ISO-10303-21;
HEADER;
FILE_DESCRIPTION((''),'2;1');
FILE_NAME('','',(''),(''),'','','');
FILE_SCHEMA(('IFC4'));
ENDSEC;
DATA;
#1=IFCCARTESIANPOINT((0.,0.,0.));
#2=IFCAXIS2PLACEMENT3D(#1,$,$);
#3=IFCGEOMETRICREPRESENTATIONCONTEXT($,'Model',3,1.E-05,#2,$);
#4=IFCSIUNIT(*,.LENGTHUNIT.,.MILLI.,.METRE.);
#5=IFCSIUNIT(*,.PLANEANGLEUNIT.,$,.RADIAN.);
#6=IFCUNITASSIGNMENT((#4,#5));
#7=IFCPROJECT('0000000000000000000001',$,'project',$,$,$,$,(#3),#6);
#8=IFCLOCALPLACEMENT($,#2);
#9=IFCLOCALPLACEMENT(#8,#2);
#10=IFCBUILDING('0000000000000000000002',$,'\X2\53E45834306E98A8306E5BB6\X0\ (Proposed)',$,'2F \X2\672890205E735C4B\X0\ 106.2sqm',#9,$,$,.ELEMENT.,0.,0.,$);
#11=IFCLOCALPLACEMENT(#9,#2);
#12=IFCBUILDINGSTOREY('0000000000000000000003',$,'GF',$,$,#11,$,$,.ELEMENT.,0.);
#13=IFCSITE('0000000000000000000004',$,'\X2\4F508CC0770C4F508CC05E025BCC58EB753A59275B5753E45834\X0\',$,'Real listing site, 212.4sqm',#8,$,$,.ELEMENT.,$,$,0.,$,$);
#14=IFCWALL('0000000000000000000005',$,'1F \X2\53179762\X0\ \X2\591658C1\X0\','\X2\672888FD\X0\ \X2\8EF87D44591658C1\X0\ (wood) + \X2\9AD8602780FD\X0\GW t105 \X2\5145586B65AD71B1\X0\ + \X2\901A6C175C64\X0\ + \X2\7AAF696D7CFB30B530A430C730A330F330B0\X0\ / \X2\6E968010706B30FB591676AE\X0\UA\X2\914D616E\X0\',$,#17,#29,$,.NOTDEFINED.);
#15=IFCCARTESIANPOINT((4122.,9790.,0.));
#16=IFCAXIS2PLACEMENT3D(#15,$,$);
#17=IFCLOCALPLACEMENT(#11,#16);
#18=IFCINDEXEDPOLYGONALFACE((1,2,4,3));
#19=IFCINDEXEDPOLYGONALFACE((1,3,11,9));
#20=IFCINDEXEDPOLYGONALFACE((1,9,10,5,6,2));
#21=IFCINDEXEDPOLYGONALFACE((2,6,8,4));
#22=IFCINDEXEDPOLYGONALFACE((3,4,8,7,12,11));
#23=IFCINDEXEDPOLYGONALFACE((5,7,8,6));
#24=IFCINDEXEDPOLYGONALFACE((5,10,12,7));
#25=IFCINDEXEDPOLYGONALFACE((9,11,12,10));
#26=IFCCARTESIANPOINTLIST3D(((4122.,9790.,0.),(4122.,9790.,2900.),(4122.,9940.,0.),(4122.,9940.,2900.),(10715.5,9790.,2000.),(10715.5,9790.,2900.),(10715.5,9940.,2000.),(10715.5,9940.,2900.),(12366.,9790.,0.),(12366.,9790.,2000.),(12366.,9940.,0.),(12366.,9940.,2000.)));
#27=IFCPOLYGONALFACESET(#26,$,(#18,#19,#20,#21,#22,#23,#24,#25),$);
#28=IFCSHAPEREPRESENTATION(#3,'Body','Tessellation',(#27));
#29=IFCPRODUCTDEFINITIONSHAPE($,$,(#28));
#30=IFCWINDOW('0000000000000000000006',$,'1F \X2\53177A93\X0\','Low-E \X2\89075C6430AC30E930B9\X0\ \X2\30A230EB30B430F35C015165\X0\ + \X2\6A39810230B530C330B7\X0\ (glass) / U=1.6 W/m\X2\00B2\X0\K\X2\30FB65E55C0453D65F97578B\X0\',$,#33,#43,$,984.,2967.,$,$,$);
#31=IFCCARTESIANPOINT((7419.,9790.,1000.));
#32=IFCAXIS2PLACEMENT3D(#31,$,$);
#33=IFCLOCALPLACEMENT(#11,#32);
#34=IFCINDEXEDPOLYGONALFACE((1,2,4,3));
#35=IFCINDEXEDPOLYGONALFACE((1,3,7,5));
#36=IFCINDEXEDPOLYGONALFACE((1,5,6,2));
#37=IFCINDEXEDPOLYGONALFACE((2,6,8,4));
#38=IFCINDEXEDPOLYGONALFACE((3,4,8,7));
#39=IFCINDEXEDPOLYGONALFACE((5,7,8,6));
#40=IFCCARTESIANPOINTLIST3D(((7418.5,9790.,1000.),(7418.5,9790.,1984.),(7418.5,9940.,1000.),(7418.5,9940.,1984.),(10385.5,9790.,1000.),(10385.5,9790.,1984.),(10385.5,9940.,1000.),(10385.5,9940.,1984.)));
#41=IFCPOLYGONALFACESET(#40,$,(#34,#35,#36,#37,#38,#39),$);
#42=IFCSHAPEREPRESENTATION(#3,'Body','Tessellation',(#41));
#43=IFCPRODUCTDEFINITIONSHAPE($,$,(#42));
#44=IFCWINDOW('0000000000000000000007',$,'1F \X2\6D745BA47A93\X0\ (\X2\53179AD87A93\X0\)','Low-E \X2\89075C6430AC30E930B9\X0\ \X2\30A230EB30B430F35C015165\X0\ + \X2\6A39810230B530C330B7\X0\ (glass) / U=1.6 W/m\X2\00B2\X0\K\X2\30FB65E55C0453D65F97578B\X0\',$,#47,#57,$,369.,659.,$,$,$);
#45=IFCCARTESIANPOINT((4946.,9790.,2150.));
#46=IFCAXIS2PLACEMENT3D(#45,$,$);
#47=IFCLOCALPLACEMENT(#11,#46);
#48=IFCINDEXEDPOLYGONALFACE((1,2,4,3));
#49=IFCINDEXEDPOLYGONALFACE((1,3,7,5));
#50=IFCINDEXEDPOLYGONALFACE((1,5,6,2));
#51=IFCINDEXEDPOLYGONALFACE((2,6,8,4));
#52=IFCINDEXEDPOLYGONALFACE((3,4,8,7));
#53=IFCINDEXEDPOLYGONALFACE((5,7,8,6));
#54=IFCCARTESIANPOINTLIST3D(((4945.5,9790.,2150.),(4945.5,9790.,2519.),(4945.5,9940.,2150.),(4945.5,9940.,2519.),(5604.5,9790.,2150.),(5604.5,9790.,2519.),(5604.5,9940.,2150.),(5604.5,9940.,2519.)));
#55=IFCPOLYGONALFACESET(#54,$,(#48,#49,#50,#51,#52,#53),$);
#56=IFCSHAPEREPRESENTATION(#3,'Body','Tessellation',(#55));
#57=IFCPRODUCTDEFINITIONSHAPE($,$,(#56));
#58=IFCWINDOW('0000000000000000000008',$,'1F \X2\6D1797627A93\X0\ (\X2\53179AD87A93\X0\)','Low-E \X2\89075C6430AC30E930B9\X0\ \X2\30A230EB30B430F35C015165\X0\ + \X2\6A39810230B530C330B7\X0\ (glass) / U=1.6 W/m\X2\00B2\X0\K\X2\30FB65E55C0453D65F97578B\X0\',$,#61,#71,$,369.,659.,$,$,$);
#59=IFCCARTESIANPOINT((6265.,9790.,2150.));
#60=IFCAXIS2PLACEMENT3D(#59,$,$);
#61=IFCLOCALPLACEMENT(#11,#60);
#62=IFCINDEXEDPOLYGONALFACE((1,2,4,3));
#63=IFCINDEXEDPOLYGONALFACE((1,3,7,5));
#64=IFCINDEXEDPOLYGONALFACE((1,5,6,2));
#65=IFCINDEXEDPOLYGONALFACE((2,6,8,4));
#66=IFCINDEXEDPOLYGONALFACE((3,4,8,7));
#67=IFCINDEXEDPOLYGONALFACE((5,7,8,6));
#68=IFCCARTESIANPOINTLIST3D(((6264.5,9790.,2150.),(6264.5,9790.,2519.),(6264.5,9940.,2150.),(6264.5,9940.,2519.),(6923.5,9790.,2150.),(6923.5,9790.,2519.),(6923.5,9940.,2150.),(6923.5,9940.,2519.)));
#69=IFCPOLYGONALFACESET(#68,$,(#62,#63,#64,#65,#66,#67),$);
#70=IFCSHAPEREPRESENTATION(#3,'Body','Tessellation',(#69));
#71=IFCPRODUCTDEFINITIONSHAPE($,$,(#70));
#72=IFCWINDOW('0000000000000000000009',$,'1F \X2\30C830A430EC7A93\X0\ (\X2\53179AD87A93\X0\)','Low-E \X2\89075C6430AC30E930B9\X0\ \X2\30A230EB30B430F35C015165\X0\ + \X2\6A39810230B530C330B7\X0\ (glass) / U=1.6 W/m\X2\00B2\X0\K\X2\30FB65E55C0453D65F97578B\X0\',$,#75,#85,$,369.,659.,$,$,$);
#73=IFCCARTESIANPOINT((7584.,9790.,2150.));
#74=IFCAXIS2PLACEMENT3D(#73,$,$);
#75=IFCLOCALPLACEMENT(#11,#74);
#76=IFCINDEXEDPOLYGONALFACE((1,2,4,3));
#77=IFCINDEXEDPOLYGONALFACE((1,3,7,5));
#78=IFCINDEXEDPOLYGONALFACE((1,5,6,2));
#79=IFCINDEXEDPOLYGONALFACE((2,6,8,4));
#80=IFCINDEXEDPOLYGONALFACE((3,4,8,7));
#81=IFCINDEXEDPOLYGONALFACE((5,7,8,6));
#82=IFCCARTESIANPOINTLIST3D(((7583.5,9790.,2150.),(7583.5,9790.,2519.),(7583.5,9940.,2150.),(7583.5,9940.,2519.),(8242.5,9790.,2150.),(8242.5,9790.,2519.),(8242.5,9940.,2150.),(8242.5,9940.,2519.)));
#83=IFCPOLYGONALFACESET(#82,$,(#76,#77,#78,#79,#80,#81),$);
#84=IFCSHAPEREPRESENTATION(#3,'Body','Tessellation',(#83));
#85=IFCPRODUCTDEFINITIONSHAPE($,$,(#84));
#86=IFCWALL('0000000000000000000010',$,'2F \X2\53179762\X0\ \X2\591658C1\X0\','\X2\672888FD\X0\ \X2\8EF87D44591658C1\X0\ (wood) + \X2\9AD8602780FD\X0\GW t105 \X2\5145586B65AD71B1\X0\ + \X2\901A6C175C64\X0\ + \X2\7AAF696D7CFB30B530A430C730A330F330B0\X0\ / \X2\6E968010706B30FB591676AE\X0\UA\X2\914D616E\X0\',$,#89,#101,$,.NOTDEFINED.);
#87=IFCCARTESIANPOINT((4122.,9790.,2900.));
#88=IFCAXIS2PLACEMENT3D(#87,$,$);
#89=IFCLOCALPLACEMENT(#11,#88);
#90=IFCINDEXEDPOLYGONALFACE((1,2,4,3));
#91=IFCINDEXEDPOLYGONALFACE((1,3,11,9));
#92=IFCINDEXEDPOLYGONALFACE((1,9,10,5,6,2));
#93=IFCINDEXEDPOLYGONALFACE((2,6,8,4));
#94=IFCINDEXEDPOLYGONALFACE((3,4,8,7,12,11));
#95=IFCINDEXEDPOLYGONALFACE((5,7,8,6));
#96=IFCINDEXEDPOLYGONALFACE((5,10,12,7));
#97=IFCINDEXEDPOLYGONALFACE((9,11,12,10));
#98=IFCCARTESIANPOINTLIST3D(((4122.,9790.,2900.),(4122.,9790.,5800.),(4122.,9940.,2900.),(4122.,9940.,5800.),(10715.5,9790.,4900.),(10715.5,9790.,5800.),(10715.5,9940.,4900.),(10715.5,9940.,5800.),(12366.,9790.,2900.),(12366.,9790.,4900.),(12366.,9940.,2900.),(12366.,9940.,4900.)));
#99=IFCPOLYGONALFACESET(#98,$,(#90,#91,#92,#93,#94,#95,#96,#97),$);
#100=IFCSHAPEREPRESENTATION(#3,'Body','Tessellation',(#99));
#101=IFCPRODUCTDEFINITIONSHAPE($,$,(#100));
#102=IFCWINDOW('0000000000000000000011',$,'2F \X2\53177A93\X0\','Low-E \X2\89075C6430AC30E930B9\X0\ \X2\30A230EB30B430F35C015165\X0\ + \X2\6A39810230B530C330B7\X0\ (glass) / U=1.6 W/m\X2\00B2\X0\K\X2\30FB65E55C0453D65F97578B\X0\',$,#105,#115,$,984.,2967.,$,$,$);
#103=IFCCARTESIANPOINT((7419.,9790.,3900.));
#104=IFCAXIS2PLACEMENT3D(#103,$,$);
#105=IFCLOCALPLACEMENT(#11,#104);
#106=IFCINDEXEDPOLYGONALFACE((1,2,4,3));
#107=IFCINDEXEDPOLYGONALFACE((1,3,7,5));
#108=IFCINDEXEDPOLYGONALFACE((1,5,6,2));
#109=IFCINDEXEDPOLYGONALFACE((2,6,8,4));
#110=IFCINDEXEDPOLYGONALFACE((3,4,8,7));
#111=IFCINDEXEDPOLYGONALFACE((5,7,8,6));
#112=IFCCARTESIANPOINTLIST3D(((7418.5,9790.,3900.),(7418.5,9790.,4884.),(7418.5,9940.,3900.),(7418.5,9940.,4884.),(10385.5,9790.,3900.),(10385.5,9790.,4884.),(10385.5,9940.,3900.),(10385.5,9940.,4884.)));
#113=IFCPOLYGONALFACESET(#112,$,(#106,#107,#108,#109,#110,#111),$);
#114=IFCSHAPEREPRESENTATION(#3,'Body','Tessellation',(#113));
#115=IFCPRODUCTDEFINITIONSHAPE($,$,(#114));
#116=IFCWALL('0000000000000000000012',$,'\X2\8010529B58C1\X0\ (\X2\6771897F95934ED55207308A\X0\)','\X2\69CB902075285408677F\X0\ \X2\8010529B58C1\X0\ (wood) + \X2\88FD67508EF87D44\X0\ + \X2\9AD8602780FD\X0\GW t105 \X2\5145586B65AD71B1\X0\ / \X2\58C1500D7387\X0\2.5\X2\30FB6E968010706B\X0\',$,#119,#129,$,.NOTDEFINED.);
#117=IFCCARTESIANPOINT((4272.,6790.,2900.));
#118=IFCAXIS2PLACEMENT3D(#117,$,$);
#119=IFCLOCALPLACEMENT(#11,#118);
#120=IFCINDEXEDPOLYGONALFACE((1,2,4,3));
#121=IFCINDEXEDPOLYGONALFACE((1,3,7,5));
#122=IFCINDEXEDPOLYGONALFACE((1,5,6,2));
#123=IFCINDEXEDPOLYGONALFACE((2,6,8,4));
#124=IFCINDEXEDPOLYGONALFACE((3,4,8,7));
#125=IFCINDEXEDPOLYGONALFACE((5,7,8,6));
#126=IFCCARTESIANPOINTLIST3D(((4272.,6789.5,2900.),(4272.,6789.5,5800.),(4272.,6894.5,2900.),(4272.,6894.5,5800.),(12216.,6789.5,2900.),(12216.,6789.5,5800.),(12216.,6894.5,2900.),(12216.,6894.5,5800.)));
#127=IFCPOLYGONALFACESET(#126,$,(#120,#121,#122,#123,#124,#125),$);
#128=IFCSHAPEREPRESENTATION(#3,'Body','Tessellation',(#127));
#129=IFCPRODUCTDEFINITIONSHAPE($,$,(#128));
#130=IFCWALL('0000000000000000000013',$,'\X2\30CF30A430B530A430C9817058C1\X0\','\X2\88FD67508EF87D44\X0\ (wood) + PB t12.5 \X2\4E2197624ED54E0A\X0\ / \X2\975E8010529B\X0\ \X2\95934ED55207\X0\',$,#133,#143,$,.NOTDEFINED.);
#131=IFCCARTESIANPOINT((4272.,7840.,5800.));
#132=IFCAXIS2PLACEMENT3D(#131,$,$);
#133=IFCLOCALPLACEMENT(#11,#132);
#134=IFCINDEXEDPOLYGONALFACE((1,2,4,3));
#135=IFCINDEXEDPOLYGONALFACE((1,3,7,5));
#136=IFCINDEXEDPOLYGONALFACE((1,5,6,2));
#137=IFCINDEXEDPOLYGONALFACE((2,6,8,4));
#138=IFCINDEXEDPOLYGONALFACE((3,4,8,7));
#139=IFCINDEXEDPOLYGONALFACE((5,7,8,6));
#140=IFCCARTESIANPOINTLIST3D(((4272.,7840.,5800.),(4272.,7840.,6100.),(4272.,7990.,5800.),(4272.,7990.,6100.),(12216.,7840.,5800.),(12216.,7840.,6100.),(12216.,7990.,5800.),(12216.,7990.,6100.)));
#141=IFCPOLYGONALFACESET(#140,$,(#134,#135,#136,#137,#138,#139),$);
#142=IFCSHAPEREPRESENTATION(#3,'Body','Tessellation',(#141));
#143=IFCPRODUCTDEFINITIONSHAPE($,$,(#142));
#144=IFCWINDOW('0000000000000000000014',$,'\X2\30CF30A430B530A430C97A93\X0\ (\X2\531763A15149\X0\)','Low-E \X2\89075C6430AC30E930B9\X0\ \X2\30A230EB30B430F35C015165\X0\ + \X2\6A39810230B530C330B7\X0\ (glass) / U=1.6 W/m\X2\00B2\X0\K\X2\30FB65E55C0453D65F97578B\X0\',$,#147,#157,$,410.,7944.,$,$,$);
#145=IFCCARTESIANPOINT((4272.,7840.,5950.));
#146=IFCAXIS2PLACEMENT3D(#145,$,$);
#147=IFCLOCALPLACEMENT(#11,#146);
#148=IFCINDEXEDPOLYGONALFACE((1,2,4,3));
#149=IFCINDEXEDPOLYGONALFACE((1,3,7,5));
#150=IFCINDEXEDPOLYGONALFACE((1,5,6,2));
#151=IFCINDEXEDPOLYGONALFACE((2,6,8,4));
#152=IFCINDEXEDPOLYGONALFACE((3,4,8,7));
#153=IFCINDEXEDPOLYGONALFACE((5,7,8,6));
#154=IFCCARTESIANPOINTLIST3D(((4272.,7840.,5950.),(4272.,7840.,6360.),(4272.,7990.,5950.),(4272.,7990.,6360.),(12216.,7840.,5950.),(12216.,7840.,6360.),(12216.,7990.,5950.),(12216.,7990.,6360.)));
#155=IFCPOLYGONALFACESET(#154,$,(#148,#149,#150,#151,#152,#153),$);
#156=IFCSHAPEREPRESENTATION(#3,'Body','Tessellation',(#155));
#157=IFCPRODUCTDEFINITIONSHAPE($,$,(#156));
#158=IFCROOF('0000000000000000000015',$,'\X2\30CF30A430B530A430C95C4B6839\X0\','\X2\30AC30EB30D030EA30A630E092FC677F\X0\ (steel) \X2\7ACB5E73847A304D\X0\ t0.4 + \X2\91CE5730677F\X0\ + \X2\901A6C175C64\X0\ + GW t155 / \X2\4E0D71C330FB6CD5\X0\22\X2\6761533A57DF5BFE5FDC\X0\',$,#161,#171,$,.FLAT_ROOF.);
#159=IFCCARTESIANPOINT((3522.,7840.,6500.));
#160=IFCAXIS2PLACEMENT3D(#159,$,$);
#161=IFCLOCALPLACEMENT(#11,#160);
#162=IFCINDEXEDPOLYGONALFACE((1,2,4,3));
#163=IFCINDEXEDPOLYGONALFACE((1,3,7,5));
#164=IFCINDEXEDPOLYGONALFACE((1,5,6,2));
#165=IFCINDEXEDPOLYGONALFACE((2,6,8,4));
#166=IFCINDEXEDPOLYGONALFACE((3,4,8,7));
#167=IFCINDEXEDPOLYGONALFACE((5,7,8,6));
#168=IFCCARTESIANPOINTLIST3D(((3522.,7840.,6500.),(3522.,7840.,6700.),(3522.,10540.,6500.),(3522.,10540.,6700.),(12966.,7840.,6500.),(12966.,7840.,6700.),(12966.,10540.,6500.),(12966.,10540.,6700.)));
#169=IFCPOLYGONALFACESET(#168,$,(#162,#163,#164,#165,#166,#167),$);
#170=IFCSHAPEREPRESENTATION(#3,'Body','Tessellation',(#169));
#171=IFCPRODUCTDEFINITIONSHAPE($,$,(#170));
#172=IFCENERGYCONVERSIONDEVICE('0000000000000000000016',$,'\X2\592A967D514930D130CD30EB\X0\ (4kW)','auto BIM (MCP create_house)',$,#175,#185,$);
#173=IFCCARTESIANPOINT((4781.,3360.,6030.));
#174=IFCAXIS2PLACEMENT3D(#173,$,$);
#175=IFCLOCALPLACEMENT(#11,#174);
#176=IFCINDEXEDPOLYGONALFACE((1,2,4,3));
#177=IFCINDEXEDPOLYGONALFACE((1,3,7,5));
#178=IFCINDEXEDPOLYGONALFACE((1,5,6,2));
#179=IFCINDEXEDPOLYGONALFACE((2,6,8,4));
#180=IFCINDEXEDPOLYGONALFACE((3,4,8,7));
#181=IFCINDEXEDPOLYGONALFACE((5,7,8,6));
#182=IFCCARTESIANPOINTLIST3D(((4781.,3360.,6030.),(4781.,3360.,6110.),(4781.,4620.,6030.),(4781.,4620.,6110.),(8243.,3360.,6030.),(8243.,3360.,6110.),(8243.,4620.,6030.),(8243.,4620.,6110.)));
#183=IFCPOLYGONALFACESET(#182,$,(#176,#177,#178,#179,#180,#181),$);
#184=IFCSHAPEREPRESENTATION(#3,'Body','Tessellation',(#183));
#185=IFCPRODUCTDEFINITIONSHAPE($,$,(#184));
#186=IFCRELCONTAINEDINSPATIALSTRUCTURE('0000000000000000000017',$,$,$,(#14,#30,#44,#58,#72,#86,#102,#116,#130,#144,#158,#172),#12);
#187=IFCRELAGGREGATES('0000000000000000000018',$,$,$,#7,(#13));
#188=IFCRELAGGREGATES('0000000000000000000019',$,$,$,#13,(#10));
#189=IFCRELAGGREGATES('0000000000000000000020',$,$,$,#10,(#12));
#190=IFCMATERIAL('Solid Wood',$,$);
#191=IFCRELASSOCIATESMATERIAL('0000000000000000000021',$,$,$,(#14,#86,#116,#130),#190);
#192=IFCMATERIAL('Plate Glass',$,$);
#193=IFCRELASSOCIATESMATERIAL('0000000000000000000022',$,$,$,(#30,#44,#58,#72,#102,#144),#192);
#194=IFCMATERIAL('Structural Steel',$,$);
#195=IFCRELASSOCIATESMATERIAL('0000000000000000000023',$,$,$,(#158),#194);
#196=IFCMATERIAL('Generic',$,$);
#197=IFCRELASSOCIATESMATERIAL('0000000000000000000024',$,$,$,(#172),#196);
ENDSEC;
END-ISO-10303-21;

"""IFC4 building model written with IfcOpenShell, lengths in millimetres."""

from ifc_helpers import new_model, si_unit, frame, frame_2d, origin, place, context, project, spatial, rectangle, extrude, material, element, fill, save


model = new_model("IFC4")

# Units and contexts
model_context = context("Model", 3, precision=1e-05, world=origin())
ifc_project = project(units=[si_unit("LENGTHUNIT", "METRE", prefix="MILLI"), si_unit("PLANEANGLEUNIT", "RADIAN")], contexts=[model_context])

# Site, building, storey
site_placement = place(None, origin())
site = spatial("IfcSite", under=ifc_project, at=site_placement, Name="佐賀県佐賀市富士町大字古場", ObjectType="Real listing site, 212.4sqm", CompositionType="ELEMENT", RefElevation=0.0)
building_placement = place(site_placement, origin())
building = spatial("IfcBuilding", under=site, at=building_placement, Name="古場の風の家 (Proposed)", ObjectType="2F 木造平屋 106.2sqm", CompositionType="ELEMENT", ElevationOfRefHeight=0.0, ElevationOfTerrain=0.0)
storey_placement = place(building_placement, origin())
storey = spatial("IfcBuildingStorey", under=building, at=storey_placement, Name="GF", CompositionType="ELEMENT", Elevation=0.0)

# Wall, openings, windows
ifc_material_1 = material(Name="Solid Wood")
wall_1_placement = place(storey_placement, frame((4122.0, 9790.0, 0.0)))
wall_1 = element("IfcWall", 1, at=wall_1_placement, inside=storey, material=ifc_material_1, Name="1F 北面 外壁", Description="木製 軸組外壁 (wood) + 高性能GW t105 充填断熱 + 通気層 + 窯業系サイディング / 準耐火・外皮UA配慮", PredefinedType="NOTDEFINED", context=model_context, shape_type="SweptSolid", body=[
    extrude(rectangle(XDim=8244.0, YDim=150.0, at=frame_2d((4122.0, 75.0))), frame((4122.0, 9790.0, 0.0)), (0.0, 0.0, 1.0), 2900.0),
])
opening_1_placement = place(storey_placement, frame((7419.0, 9790.0, 1000.0)))
opening_1 = element("IfcOpeningElement", 2, at=opening_1_placement, cuts=wall_1, PredefinedType="NOTDEFINED", context=model_context, shape_type="SweptSolid", body=[
    extrude(rectangle(XDim=2967.0, YDim=150.0, at=frame_2d((1483.0, 75.0))), frame((7419.0, 9790.0, 1000.0)), (0.0, 0.0, 1.0), 984.0),
])
opening_2_placement = place(storey_placement, frame((4946.0, 9790.0, 2150.0)))
opening_2 = element("IfcOpeningElement", 3, at=opening_2_placement, cuts=wall_1, PredefinedType="NOTDEFINED", context=model_context, shape_type="SweptSolid", body=[
    extrude(rectangle(XDim=659.0, YDim=150.0, at=frame_2d((329.0, 75.0))), frame((4946.0, 9790.0, 2150.0)), (0.0, 0.0, 1.0), 369.0),
])
opening_3_placement = place(storey_placement, frame((6265.0, 9790.0, 2150.0)))
opening_3 = element("IfcOpeningElement", 4, at=opening_3_placement, cuts=wall_1, PredefinedType="NOTDEFINED", context=model_context, shape_type="SweptSolid", body=[
    extrude(rectangle(XDim=659.0, YDim=150.0, at=frame_2d((329.0, 75.0))), frame((6265.0, 9790.0, 2150.0)), (0.0, 0.0, 1.0), 369.0),
])
opening_4_placement = place(storey_placement, frame((7584.0, 9790.0, 2150.0)))
opening_4 = element("IfcOpeningElement", 5, at=opening_4_placement, cuts=wall_1, PredefinedType="NOTDEFINED", context=model_context, shape_type="SweptSolid", body=[
    extrude(rectangle(XDim=659.0, YDim=150.0, at=frame_2d((329.0, 75.0))), frame((7584.0, 9790.0, 2150.0)), (0.0, 0.0, 1.0), 369.0),
])
ifc_material_2 = material(Name="Plate Glass")
window_1_placement = place(storey_placement, frame((7419.0, 9790.0, 1000.0)))
window_1 = element("IfcWindow", 6, at=window_1_placement, inside=storey, material=ifc_material_2, Name="1F 北窓", Description="Low-E 複層ガラス アルゴン封入 + 樹脂サッシ (glass) / U=1.6 W/m²K・日射取得型", OverallHeight=984.0, OverallWidth=2967.0, context=model_context, shape_type="SweptSolid", body=[
    extrude(rectangle(XDim=2967.0, YDim=150.0, at=frame_2d((1483.0, 75.0))), frame((7419.0, 9790.0, 1000.0)), (0.0, 0.0, 1.0), 984.0),
])
fill(opening_1, window_1)
window_2_placement = place(storey_placement, frame((4946.0, 9790.0, 2150.0)))
window_2 = element("IfcWindow", 7, at=window_2_placement, inside=storey, material=ifc_material_2, Name="1F 浴室窓 (北高窓)", Description="Low-E 複層ガラス アルゴン封入 + 樹脂サッシ (glass) / U=1.6 W/m²K・日射取得型", OverallHeight=369.0, OverallWidth=659.0, context=model_context, shape_type="SweptSolid", body=[
    extrude(rectangle(XDim=659.0, YDim=150.0, at=frame_2d((329.0, 75.0))), frame((4946.0, 9790.0, 2150.0)), (0.0, 0.0, 1.0), 369.0),
])
fill(opening_2, window_2)
window_3_placement = place(storey_placement, frame((6265.0, 9790.0, 2150.0)))
window_3 = element("IfcWindow", 8, at=window_3_placement, inside=storey, material=ifc_material_2, Name="1F 洗面窓 (北高窓)", Description="Low-E 複層ガラス アルゴン封入 + 樹脂サッシ (glass) / U=1.6 W/m²K・日射取得型", OverallHeight=369.0, OverallWidth=659.0, context=model_context, shape_type="SweptSolid", body=[
    extrude(rectangle(XDim=659.0, YDim=150.0, at=frame_2d((329.0, 75.0))), frame((6265.0, 9790.0, 2150.0)), (0.0, 0.0, 1.0), 369.0),
])
fill(opening_3, window_3)
window_4_placement = place(storey_placement, frame((7584.0, 9790.0, 2150.0)))
window_4 = element("IfcWindow", 9, at=window_4_placement, inside=storey, material=ifc_material_2, Name="1F トイレ窓 (北高窓)", Description="Low-E 複層ガラス アルゴン封入 + 樹脂サッシ (glass) / U=1.6 W/m²K・日射取得型", OverallHeight=369.0, OverallWidth=659.0, context=model_context, shape_type="SweptSolid", body=[
    extrude(rectangle(XDim=659.0, YDim=150.0, at=frame_2d((329.0, 75.0))), frame((7584.0, 9790.0, 2150.0)), (0.0, 0.0, 1.0), 369.0),
])
fill(opening_4, window_4)

# Wall, opening, window
wall_2_placement = place(storey_placement, frame((4122.0, 9790.0, 2900.0)))
wall_2 = element("IfcWall", 10, at=wall_2_placement, inside=storey, material=ifc_material_1, Name="2F 北面 外壁", Description="木製 軸組外壁 (wood) + 高性能GW t105 充填断熱 + 通気層 + 窯業系サイディング / 準耐火・外皮UA配慮", PredefinedType="NOTDEFINED", context=model_context, shape_type="SweptSolid", body=[
    extrude(rectangle(XDim=8244.0, YDim=150.0, at=frame_2d((4122.0, 75.0))), frame((4122.0, 9790.0, 2900.0)), (0.0, 0.0, 1.0), 2900.0),
])
opening_5_placement = place(storey_placement, frame((7419.0, 9790.0, 3900.0)))
opening_5 = element("IfcOpeningElement", 11, at=opening_5_placement, cuts=wall_2, PredefinedType="NOTDEFINED", context=model_context, shape_type="SweptSolid", body=[
    extrude(rectangle(XDim=2967.0, YDim=150.0, at=frame_2d((1483.0, 75.0))), frame((7419.0, 9790.0, 3900.0)), (0.0, 0.0, 1.0), 984.0),
])
window_5_placement = place(storey_placement, frame((7419.0, 9790.0, 3900.0)))
window_5 = element("IfcWindow", 12, at=window_5_placement, inside=storey, material=ifc_material_2, Name="2F 北窓", Description="Low-E 複層ガラス アルゴン封入 + 樹脂サッシ (glass) / U=1.6 W/m²K・日射取得型", OverallHeight=984.0, OverallWidth=2967.0, context=model_context, shape_type="SweptSolid", body=[
    extrude(rectangle(XDim=2967.0, YDim=150.0, at=frame_2d((1483.0, 75.0))), frame((7419.0, 9790.0, 3900.0)), (0.0, 0.0, 1.0), 984.0),
])
fill(opening_5, window_5)

# Wall
wall_3_placement = place(storey_placement, frame((4272.0, 6790.0, 2900.0)))
element("IfcWall", 13, at=wall_3_placement, inside=storey, material=ifc_material_1, Name="耐力壁 (東西間仕切り)", Description="構造用合板 耐力壁 (wood) + 製材軸組 + 高性能GW t105 充填断熱 / 壁倍率2.5・準耐火", PredefinedType="NOTDEFINED", context=model_context, shape_type="SweptSolid", body=[
    extrude(rectangle(XDim=7944.0, YDim=105.0, at=frame_2d((3972.0, 52.0))), frame((4272.0, 6790.0, 2900.0)), (0.0, 0.0, 1.0), 2900.0),
])

# Wall, opening, window
wall_4_placement = place(storey_placement, frame((4272.0, 7840.0, 5800.0)))
wall_4 = element("IfcWall", 14, at=wall_4_placement, inside=storey, material=ifc_material_1, Name="ハイサイド腰壁", Description="製材軸組 (wood) + PB t12.5 両面仕上 / 非耐力 間仕切", PredefinedType="NOTDEFINED", context=model_context, shape_type="SweptSolid", body=[
    extrude(rectangle(XDim=7944.0, YDim=150.0, at=frame_2d((3972.0, 75.0))), frame((4272.0, 7840.0, 5800.0)), (0.0, 0.0, 1.0), 700.0),
])
opening_6_placement = place(storey_placement, frame((4272.0, 7840.0, 5950.0)))
opening_6 = element("IfcOpeningElement", 15, at=opening_6_placement, cuts=wall_4, PredefinedType="NOTDEFINED", context=model_context, shape_type="SweptSolid", body=[
    extrude(rectangle(XDim=7944.0, YDim=150.0, at=frame_2d((3972.0, 75.0))), frame((4272.0, 7840.0, 5950.0)), (0.0, 0.0, 1.0), 410.0),
])
window_6_placement = place(storey_placement, frame((4272.0, 7840.0, 5950.0)))
window_6 = element("IfcWindow", 16, at=window_6_placement, inside=storey, material=ifc_material_2, Name="ハイサイド窓 (北採光)", Description="Low-E 複層ガラス アルゴン封入 + 樹脂サッシ (glass) / U=1.6 W/m²K・日射取得型", OverallHeight=410.0, OverallWidth=7944.0, context=model_context, shape_type="SweptSolid", body=[
    extrude(rectangle(XDim=7944.0, YDim=150.0, at=frame_2d((3972.0, 75.0))), frame((4272.0, 7840.0, 5950.0)), (0.0, 0.0, 1.0), 410.0),
])
fill(opening_6, window_6)

# Roof
ifc_material_3 = material(Name="Structural Steel")
roof_placement = place(storey_placement, frame((3522.0, 7840.0, 6500.0)))
element("IfcRoof", 17, at=roof_placement, inside=storey, material=ifc_material_3, Name="ハイサイド屋根", Description="ガルバリウム鋼板 (steel) 立平葺き t0.4 + 野地板 + 通気層 + GW t155 / 不燃・法22条区域対応", PredefinedType="FLAT_ROOF", context=model_context, shape_type="SweptSolid", body=[
    extrude(rectangle(XDim=9444.0, YDim=2700.0, at=frame_2d((4722.0, 1350.0))), frame((3522.0, 7840.0, 6500.0)), (0.0, 0.0, 1.0), 200.0),
])

# Energy conversion device
ifc_material_4 = material(Name="Generic")
energy_conversion_device_placement = place(storey_placement, frame((4781.0, 3360.0, 6030.0)))
element("IfcEnergyConversionDevice", 18, at=energy_conversion_device_placement, inside=storey, material=ifc_material_4, Name="太陽光パネル (4kW)", Description="auto BIM (MCP create_house)", context=model_context, shape_type="SweptSolid", body=[
    extrude(rectangle(XDim=3462.0, YDim=1260.0, at=frame_2d((1731.0, 630.0))), frame((4781.0, 3360.0, 6030.0)), (0.0, 0.0, 1.0), 80.0),
])

save(model, "model.ifc")
